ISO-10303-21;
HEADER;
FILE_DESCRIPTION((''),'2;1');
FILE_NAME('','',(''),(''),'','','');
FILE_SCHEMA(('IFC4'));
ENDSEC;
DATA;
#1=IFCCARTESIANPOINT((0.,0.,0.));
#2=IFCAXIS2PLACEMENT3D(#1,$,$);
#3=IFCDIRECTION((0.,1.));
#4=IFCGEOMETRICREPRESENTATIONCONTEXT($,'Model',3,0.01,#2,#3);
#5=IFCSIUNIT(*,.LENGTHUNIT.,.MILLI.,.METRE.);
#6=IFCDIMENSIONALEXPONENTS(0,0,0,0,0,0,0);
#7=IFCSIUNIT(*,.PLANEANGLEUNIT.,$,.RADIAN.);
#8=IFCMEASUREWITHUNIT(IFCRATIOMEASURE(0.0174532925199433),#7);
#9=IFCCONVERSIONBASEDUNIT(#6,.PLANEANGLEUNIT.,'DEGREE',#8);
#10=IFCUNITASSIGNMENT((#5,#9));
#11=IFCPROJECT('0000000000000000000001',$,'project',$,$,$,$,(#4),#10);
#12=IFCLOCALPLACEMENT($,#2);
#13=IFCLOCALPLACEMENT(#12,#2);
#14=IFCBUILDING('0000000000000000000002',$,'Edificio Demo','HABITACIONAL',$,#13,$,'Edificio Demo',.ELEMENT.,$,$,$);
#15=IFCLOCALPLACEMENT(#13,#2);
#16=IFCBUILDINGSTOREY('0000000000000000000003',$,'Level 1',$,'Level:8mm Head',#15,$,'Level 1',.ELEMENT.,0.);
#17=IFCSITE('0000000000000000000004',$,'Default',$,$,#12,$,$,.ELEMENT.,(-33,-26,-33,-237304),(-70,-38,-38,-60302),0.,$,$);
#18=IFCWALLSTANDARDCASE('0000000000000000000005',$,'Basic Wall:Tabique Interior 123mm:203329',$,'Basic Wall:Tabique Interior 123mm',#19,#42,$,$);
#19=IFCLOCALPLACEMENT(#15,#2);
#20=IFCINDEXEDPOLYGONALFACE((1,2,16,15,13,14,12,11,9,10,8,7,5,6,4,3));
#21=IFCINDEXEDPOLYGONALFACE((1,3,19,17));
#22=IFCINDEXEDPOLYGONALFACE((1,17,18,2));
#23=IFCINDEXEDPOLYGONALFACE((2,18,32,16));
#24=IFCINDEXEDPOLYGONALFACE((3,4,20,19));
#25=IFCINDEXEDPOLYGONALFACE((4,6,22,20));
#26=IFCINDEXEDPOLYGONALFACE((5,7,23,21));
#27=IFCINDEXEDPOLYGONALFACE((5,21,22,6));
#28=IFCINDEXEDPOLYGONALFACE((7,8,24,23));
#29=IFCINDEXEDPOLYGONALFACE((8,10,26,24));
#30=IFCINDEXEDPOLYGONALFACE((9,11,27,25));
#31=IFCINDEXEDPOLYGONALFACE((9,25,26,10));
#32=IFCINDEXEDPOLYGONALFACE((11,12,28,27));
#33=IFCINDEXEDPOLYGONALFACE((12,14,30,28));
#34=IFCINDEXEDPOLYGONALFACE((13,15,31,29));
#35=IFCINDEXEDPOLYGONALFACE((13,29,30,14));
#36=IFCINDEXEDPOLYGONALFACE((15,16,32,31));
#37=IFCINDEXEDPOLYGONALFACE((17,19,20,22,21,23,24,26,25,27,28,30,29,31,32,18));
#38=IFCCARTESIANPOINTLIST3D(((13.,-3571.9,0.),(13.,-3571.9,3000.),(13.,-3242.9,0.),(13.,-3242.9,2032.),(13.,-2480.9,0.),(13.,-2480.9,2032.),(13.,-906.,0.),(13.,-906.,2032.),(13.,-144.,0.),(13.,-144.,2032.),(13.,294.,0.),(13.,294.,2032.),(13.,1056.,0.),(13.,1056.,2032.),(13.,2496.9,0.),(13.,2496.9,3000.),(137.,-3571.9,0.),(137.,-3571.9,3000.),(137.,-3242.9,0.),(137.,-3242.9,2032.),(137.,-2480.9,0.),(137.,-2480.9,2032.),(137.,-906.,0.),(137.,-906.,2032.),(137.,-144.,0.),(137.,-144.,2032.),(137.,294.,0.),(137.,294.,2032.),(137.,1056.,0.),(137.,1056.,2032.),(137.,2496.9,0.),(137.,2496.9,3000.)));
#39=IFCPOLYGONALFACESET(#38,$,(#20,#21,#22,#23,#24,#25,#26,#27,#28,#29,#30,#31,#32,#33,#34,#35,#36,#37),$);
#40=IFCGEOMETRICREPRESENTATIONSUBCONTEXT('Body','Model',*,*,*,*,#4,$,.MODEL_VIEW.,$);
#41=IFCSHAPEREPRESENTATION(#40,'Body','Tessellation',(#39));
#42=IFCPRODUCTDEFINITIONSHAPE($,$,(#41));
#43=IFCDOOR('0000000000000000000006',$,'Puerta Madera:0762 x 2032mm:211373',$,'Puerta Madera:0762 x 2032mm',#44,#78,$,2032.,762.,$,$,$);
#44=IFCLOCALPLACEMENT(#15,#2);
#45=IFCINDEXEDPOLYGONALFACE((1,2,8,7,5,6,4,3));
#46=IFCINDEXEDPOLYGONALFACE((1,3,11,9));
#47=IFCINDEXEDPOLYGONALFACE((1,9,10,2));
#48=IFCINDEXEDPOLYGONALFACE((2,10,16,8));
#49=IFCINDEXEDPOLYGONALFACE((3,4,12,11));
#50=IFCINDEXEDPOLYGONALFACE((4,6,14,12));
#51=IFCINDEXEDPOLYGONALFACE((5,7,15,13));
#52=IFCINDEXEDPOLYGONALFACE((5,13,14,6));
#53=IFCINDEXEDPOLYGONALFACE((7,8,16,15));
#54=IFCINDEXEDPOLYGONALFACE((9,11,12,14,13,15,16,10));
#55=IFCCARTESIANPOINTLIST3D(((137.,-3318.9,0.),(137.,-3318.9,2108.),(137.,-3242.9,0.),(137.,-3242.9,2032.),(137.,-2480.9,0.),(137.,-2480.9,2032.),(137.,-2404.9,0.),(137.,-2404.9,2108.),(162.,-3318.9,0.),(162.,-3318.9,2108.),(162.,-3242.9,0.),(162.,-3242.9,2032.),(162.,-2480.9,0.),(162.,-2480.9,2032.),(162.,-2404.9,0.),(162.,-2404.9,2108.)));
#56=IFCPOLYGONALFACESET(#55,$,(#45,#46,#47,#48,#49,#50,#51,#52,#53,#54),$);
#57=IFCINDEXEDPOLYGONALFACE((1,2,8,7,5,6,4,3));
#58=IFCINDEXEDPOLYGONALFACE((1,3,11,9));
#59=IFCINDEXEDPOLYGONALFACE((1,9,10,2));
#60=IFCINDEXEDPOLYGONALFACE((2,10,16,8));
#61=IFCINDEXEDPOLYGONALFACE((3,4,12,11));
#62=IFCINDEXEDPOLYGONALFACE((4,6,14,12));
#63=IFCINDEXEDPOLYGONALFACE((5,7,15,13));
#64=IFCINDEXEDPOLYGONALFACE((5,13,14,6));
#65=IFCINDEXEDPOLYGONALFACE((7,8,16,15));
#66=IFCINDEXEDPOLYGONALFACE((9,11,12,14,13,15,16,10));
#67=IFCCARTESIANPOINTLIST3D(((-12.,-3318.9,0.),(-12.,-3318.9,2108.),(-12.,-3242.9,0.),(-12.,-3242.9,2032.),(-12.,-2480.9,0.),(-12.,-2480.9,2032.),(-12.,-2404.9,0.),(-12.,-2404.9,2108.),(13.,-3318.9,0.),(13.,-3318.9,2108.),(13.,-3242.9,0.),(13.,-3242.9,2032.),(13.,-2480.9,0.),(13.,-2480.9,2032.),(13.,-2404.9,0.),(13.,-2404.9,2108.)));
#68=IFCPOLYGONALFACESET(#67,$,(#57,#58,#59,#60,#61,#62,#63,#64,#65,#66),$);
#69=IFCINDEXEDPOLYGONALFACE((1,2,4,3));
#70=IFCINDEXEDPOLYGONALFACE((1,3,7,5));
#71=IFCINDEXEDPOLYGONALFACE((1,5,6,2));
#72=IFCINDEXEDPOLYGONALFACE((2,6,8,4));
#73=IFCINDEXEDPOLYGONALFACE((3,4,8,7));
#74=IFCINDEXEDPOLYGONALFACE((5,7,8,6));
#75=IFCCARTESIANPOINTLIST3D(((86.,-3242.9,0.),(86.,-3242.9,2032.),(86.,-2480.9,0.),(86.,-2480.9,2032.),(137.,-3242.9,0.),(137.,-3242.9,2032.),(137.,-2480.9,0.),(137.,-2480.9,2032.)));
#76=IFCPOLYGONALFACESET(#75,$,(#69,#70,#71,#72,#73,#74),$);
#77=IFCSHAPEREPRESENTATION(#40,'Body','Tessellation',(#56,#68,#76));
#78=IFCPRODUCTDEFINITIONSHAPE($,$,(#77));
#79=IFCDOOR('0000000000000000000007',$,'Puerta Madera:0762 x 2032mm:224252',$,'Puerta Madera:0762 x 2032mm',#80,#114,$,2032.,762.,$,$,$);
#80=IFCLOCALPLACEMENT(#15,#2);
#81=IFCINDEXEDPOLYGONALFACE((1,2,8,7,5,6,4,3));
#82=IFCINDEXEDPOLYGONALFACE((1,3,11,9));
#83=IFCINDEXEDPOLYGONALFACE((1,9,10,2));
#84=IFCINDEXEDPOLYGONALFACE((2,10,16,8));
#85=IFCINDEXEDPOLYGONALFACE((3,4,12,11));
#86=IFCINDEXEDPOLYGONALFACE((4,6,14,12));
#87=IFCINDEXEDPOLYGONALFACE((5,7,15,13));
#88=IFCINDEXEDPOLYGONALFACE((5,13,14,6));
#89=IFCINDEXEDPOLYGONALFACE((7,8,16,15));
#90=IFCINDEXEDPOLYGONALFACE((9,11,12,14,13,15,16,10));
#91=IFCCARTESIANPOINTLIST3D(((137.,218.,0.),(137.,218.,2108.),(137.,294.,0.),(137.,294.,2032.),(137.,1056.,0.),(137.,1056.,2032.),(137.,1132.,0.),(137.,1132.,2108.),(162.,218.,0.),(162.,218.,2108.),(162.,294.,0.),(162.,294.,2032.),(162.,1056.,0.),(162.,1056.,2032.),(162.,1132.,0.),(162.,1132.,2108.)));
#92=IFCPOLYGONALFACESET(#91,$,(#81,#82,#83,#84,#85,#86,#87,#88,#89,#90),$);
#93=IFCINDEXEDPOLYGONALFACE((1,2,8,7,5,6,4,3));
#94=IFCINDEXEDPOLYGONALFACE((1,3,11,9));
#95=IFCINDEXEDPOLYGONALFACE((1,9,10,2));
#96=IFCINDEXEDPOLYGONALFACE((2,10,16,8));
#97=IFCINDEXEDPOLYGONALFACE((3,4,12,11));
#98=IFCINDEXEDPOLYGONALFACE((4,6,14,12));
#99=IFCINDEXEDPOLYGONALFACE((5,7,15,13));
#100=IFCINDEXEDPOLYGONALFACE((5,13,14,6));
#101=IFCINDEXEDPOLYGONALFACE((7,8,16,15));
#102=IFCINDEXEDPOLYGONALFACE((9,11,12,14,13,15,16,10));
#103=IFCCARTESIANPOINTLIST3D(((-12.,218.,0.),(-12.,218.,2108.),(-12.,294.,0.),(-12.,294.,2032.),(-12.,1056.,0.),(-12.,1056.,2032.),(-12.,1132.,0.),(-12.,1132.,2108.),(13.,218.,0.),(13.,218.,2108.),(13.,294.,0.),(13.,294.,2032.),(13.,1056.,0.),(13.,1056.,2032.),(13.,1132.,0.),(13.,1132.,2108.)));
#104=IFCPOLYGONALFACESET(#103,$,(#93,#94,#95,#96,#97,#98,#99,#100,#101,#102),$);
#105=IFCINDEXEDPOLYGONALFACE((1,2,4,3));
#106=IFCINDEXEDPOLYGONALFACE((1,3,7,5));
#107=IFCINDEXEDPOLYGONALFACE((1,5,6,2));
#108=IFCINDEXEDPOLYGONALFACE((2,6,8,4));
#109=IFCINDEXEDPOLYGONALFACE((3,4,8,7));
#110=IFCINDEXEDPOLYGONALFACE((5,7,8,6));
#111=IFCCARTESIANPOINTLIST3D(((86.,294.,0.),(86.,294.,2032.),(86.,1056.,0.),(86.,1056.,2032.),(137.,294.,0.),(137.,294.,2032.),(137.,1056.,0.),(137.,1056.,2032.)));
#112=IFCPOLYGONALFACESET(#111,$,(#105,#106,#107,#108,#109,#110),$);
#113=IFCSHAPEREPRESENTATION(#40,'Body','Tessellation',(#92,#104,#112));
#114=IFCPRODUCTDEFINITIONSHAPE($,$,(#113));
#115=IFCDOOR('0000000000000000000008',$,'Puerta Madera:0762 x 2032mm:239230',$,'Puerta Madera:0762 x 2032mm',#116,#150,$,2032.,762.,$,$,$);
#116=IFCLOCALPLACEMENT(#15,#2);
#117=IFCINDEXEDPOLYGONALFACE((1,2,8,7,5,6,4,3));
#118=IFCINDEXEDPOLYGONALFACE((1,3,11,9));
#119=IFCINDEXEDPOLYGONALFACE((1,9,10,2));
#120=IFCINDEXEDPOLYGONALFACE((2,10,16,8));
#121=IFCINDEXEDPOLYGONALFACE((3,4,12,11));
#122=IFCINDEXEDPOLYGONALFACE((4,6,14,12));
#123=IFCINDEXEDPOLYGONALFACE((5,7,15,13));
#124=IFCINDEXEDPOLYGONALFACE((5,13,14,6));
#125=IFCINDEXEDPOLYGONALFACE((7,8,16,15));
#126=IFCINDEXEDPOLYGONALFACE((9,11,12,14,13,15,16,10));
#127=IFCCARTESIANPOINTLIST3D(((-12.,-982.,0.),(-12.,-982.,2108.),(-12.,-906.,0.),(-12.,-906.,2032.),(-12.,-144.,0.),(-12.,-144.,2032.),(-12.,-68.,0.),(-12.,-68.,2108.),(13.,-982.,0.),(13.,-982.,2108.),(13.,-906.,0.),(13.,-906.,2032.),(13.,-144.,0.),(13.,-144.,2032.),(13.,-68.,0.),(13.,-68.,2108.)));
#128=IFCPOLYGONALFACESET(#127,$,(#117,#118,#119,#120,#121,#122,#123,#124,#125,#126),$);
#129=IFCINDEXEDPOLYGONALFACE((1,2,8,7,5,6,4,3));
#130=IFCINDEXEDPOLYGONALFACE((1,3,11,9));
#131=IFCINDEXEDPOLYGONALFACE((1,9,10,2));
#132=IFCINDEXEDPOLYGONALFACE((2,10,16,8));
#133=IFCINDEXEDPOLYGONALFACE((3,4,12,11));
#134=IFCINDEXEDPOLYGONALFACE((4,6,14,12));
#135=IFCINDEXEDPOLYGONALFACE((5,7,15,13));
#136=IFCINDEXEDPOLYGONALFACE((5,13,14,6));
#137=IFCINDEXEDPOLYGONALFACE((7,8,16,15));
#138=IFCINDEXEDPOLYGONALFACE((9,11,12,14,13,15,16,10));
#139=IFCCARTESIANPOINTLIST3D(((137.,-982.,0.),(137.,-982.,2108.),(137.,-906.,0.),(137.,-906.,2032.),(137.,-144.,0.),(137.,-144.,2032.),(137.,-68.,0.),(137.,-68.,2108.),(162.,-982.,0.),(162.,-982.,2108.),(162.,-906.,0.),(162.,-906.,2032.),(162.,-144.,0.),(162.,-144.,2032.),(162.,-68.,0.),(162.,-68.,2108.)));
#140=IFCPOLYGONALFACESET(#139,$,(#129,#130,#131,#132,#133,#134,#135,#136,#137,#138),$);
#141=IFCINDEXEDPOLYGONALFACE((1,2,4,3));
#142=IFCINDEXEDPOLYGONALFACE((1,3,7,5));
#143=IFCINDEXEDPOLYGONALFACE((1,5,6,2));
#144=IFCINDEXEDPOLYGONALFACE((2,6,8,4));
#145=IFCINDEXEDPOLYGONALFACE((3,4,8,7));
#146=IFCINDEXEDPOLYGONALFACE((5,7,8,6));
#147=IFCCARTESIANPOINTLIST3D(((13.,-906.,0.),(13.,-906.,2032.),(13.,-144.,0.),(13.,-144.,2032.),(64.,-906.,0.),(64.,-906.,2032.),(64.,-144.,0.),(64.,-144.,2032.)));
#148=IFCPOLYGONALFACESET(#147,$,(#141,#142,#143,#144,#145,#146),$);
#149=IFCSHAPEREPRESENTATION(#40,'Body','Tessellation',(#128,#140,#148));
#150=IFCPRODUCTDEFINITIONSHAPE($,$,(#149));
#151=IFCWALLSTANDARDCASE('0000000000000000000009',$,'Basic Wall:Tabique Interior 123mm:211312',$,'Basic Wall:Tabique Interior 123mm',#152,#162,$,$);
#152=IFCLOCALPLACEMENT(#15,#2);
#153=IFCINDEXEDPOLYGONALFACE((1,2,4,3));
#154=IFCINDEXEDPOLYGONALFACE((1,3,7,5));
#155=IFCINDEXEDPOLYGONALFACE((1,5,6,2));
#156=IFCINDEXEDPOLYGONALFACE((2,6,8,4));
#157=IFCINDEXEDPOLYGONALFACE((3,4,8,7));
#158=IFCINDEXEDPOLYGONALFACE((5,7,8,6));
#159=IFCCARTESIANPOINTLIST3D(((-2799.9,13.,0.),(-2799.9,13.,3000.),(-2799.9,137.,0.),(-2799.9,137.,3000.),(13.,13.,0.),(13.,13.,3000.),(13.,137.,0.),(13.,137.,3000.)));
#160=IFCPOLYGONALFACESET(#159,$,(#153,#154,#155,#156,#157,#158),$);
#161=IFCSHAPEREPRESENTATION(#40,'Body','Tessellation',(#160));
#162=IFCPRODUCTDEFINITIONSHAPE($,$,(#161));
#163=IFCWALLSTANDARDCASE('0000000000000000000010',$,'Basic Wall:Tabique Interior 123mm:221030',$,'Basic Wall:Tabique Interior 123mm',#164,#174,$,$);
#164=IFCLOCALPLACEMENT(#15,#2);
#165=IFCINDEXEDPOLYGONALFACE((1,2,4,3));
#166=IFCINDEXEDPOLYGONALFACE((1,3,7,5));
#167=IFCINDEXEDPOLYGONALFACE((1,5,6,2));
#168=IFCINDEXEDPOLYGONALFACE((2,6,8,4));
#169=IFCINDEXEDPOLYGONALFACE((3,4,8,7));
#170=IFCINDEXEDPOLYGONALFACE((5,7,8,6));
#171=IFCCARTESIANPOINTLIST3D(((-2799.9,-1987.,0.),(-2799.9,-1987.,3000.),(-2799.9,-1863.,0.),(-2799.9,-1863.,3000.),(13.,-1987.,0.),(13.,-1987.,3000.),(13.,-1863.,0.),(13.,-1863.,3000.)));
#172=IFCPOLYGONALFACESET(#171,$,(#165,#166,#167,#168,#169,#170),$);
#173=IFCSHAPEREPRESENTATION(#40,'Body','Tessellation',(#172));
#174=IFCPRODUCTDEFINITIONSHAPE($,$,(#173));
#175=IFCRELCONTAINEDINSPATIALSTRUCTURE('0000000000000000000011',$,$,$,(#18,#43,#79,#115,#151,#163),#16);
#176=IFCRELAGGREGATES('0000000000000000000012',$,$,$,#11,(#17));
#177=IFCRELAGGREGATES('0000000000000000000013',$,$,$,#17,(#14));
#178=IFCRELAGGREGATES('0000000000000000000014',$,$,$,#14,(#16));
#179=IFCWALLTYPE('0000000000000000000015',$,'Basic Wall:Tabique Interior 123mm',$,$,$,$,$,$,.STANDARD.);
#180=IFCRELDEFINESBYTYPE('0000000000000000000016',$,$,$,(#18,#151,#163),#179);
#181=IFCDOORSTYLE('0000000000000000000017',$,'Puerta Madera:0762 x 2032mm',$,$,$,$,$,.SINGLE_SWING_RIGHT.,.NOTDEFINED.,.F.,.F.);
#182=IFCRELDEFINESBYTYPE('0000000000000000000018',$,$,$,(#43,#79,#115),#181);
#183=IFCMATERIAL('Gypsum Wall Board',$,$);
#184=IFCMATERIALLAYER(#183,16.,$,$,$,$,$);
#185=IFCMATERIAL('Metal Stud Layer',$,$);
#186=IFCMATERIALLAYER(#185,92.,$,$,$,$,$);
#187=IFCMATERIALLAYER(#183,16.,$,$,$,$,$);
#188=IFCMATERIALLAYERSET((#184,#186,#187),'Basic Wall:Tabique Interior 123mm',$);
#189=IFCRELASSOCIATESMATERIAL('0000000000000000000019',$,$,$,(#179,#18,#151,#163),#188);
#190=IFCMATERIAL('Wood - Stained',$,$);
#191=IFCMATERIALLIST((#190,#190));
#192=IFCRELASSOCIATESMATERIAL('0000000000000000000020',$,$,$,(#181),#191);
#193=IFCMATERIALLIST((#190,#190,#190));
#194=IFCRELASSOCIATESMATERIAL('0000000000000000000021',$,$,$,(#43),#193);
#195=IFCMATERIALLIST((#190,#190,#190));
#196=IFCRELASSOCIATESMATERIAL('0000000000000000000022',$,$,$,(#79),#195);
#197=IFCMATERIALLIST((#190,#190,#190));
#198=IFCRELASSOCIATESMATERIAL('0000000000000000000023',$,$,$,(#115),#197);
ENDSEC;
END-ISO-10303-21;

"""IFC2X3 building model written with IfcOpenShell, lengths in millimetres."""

from ifc_helpers import new_model, entity, si_unit, converted_unit, direction, frame, frame_2d, origin, place, context, subcontext, project, spatial, polyline, rectangle, outline, extrude, source, transform, mapped, material, material_list, layer, layer_set, layer_usage, type_object, type_shapes, element, fill, save


model = new_model("IFC2X3")

# Units and contexts
model_context = context("Model", 3, precision=0.01, world=origin(), true_north=direction((0.0, 1.0)))
body_context = subcontext(model_context, "Body", "Model", "MODEL_VIEW")
ifc_project = project(units=[si_unit("LENGTHUNIT", "METRE", prefix="MILLI"), converted_unit("PLANEANGLEUNIT", "DEGREE", entity("IfcRatioMeasure", 0.0174532925199433), si_unit("PLANEANGLEUNIT", "RADIAN"), dimensions=[0, 0, 0, 0, 0, 0, 0])], contexts=[model_context])

# Site, building, storey
site_placement = place(None, origin())
site = spatial("IfcSite", under=ifc_project, at=site_placement, Name="Default", CompositionType="ELEMENT", RefLatitude=(-33, -26, -33, -237304), RefLongitude=(-70, -38, -38, -60302), RefElevation=0.0)
building_placement = place(site_placement, origin())
building = spatial("IfcBuilding", under=site, at=building_placement, Name="Edificio Demo", Description="HABITACIONAL", LongName="Edificio Demo", CompositionType="ELEMENT")
storey_placement = place(building_placement, origin())
storey = spatial("IfcBuildingStorey", under=building, at=storey_placement, Name="Level 1", ObjectType="Level:8mm Head", LongName="Level 1", CompositionType="ELEMENT", Elevation=0.0)

# Shared definitions
ifc_material_1 = material(Name="Wood - Stained")

# Wall, openings, doors
ifc_material_2 = material(Name="Gypsum Wall Board")
ifc_layer_1 = layer(ifc_material_2, 16.0)
ifc_material_3 = material(Name="Metal Stud Layer")
ifc_layer_2 = layer(ifc_material_3, 92.0)
ifc_layer_3 = layer(ifc_material_2, 16.0)
ifc_layer_set_1 = layer_set([ifc_layer_1, ifc_layer_2, ifc_layer_3], Name="Basic Wall:Tabique Interior 123mm")
ifc_layer_usage_1 = layer_usage(ifc_layer_set_1, "AXIS2", "NEGATIVE", 62.0)
wall_type_1 = type_object("IfcWallType", Name="Basic Wall:Tabique Interior 123mm", PredefinedType="STANDARD", material=ifc_layer_set_1)
wall_1_placement = place(storey_placement, frame((75.0, -3571.9, 0.0), z_axis=(0.0, 0.0, 1.0), x_axis=(0.0, 1.0, 0.0)))
wall_1 = element("IfcWallStandardCase", 1, at=wall_1_placement, inside=storey, type_object=wall_type_1, material=ifc_layer_usage_1, Name="Basic Wall:Tabique Interior 123mm:203329", ObjectType="Basic Wall:Tabique Interior 123mm", context=body_context, shape_type="SweptSolid", body=[
    extrude(rectangle(XDim=6068.8, YDim=124.0, at=frame_2d((3034.4, 0.0), x_axis=(-1.0, 0.0))), origin(), (0.0, 0.0, 1.0), 3000.0),
])
opening_1_placement = place(wall_1_placement, frame((1091.0, 62.0, 0.0)))
opening_1 = element("IfcOpeningElement", 2, at=opening_1_placement, cuts=wall_1, ObjectType="Opening", context=body_context, shape_type="SweptSolid", body=[
    extrude(rectangle(XDim=762.0, YDim=2032.0, at=frame_2d((1016.0, 381.0), x_axis=(0.0, 1.0))), frame((0.0, 0.0, 0.0), z_axis=(0.0, -1.0, 0.0), x_axis=(0.0, 0.0, 1.0)), (0.0, 0.0, 1.0), 124.0),
])
opening_2_placement = place(wall_1_placement, frame((4627.9, 62.0, 0.0)))
opening_2 = element("IfcOpeningElement", 3, at=opening_2_placement, cuts=wall_1, ObjectType="Opening", context=body_context, shape_type="SweptSolid", body=[
    extrude(rectangle(XDim=762.0, YDim=2032.0, at=frame_2d((1016.0, 381.0), x_axis=(0.0, 1.0))), frame((0.0, 0.0, 0.0), z_axis=(0.0, -1.0, 0.0), x_axis=(0.0, 0.0, 1.0)), (0.0, 0.0, 1.0), 124.0),
])
opening_3_placement = place(wall_1_placement, frame((2665.9, -62.0, 0.0)))
opening_3 = element("IfcOpeningElement", 4, at=opening_3_placement, cuts=wall_1, ObjectType="Opening", context=body_context, shape_type="SweptSolid", body=[
    extrude(rectangle(XDim=762.0, YDim=2032.0, at=frame_2d((1016.0, 381.0), x_axis=(0.0, 1.0))), frame((0.0, 0.0, 0.0), z_axis=(0.0, 1.0, 0.0), x_axis=(0.0, 0.0, 1.0)), (0.0, 0.0, 1.0), 124.0),
])
ifc_material_list_1 = material_list([ifc_material_1, ifc_material_1, ifc_material_1])
ifc_material_list_2 = material_list([ifc_material_1, ifc_material_1])
door_style_1 = type_object("IfcDoorStyle", Name="Puerta Madera:0762 x 2032mm", ConstructionType="NOTDEFINED", OperationType="SINGLE_SWING_RIGHT", ParameterTakesPrecedence=False, Sizeable=False, material=ifc_material_list_2)
shared_shape_1 = source(origin(), body_context, "Body", "SweptSolid", [
    extrude(outline(polyline([(-457.0, -1073.0), (457.0, -1073.0), (457.0, 1035.0), (381.0, 1035.0), (381.0, -997.0), (-381.0, -997.0), (-381.0, 1035.0), (-457.0, 1035.0), (-457.0, -1073.0)])), frame((381.0, 124.0, 1035.0), z_axis=(0.0, 1.0, 0.0), x_axis=(1.0, 0.0, 0.0)), (0.0, 0.0, 1.0), 25.0),
    extrude(outline(polyline([(-1073.0, -457.0), (1035.0, -457.0), (1035.0, -381.0), (-997.0, -381.0), (-997.0, 381.0), (1035.0, 381.0), (1035.0, 457.0), (-1073.0, 457.0), (-1073.0, -457.0)])), frame((381.0, -25.0, 1035.0), z_axis=(0.0, 1.0, 0.0), x_axis=(0.0, 0.0, -1.0)), (0.0, 0.0, 1.0), 25.0),
    extrude(rectangle(XDim=51.0, YDim=762.0, at=frame_2d((0.0, 0.0), x_axis=(1.0, 0.0))), frame((381.0, 98.5, 0.0), z_axis=(0.0, 0.0, 1.0), x_axis=(0.0, 1.0, 0.0)), (0.0, 0.0, 1.0), 2032.0),
])
type_shapes(door_style_1, [shared_shape_1])
door_1_placement = place(opening_1_placement, frame((0.0, 0.0, 0.0), z_axis=(0.0, 0.0, 1.0), x_axis=(-1.0, 0.0, 0.0)))
door_1 = element("IfcDoor", 5, at=door_1_placement, inside=storey, type_object=door_style_1, material=ifc_material_list_1, Name="Puerta Madera:0762 x 2032mm:211373", ObjectType="Puerta Madera:0762 x 2032mm", OverallHeight=2032.0, OverallWidth=762.0, context=body_context, shape_type="MappedRepresentation", body=[
    mapped(shared_shape_1, transform((0.0, 0.0, 0.0), scale=1.0)),
])
fill(opening_1, door_1)
ifc_material_list_3 = material_list([ifc_material_1, ifc_material_1, ifc_material_1])
door_2_placement = place(opening_2_placement, frame((0.0, 0.0, 0.0), z_axis=(0.0, 0.0, 1.0), x_axis=(-1.0, 0.0, 0.0)))
door_2 = element("IfcDoor", 6, at=door_2_placement, inside=storey, type_object=door_style_1, material=ifc_material_list_3, Name="Puerta Madera:0762 x 2032mm:224252", ObjectType="Puerta Madera:0762 x 2032mm", OverallHeight=2032.0, OverallWidth=762.0, context=body_context, shape_type="MappedRepresentation", body=[
    mapped(shared_shape_1, transform((0.0, 0.0, 0.0), scale=1.0)),
])
fill(opening_2, door_2)
ifc_material_list_4 = material_list([ifc_material_1, ifc_material_1, ifc_material_1])
door_3_placement = place(opening_3_placement, origin())
door_3 = element("IfcDoor", 7, at=door_3_placement, inside=storey, type_object=door_style_1, material=ifc_material_list_4, Name="Puerta Madera:0762 x 2032mm:239230", ObjectType="Puerta Madera:0762 x 2032mm", OverallHeight=2032.0, OverallWidth=762.0, context=body_context, shape_type="MappedRepresentation", body=[
    mapped(shared_shape_1, transform((0.0, 0.0, 0.0), scale=1.0)),
])
fill(opening_3, door_3)

# Walls
ifc_layer_usage_2 = layer_usage(ifc_layer_set_1, "AXIS2", "POSITIVE", -62.0)
wall_2_placement = place(storey_placement, frame((-2799.9, 75.0, 0.0)))
element("IfcWallStandardCase", 8, at=wall_2_placement, inside=storey, type_object=wall_type_1, material=ifc_layer_usage_2, Name="Basic Wall:Tabique Interior 123mm:211312", ObjectType="Basic Wall:Tabique Interior 123mm", context=body_context, shape_type="SweptSolid", body=[
    extrude(rectangle(XDim=2812.9, YDim=124.0, at=frame_2d((1406.4, 0.0), x_axis=(-1.0, 0.0))), origin(), (0.0, 0.0, 1.0), 3000.0),
])
ifc_layer_usage_3 = layer_usage(ifc_layer_set_1, "AXIS2", "POSITIVE", -62.0)
wall_3_placement = place(storey_placement, frame((-2799.9, -1925.0, 0.0)))
element("IfcWallStandardCase", 9, at=wall_3_placement, inside=storey, type_object=wall_type_1, material=ifc_layer_usage_3, Name="Basic Wall:Tabique Interior 123mm:221030", ObjectType="Basic Wall:Tabique Interior 123mm", context=body_context, shape_type="SweptSolid", body=[
    extrude(rectangle(XDim=2812.9, YDim=124.0, at=frame_2d((1406.4, 0.0), x_axis=(-1.0, 0.0))), origin(), (0.0, 0.0, 1.0), 3000.0),
])

save(model, "model.ifc")
